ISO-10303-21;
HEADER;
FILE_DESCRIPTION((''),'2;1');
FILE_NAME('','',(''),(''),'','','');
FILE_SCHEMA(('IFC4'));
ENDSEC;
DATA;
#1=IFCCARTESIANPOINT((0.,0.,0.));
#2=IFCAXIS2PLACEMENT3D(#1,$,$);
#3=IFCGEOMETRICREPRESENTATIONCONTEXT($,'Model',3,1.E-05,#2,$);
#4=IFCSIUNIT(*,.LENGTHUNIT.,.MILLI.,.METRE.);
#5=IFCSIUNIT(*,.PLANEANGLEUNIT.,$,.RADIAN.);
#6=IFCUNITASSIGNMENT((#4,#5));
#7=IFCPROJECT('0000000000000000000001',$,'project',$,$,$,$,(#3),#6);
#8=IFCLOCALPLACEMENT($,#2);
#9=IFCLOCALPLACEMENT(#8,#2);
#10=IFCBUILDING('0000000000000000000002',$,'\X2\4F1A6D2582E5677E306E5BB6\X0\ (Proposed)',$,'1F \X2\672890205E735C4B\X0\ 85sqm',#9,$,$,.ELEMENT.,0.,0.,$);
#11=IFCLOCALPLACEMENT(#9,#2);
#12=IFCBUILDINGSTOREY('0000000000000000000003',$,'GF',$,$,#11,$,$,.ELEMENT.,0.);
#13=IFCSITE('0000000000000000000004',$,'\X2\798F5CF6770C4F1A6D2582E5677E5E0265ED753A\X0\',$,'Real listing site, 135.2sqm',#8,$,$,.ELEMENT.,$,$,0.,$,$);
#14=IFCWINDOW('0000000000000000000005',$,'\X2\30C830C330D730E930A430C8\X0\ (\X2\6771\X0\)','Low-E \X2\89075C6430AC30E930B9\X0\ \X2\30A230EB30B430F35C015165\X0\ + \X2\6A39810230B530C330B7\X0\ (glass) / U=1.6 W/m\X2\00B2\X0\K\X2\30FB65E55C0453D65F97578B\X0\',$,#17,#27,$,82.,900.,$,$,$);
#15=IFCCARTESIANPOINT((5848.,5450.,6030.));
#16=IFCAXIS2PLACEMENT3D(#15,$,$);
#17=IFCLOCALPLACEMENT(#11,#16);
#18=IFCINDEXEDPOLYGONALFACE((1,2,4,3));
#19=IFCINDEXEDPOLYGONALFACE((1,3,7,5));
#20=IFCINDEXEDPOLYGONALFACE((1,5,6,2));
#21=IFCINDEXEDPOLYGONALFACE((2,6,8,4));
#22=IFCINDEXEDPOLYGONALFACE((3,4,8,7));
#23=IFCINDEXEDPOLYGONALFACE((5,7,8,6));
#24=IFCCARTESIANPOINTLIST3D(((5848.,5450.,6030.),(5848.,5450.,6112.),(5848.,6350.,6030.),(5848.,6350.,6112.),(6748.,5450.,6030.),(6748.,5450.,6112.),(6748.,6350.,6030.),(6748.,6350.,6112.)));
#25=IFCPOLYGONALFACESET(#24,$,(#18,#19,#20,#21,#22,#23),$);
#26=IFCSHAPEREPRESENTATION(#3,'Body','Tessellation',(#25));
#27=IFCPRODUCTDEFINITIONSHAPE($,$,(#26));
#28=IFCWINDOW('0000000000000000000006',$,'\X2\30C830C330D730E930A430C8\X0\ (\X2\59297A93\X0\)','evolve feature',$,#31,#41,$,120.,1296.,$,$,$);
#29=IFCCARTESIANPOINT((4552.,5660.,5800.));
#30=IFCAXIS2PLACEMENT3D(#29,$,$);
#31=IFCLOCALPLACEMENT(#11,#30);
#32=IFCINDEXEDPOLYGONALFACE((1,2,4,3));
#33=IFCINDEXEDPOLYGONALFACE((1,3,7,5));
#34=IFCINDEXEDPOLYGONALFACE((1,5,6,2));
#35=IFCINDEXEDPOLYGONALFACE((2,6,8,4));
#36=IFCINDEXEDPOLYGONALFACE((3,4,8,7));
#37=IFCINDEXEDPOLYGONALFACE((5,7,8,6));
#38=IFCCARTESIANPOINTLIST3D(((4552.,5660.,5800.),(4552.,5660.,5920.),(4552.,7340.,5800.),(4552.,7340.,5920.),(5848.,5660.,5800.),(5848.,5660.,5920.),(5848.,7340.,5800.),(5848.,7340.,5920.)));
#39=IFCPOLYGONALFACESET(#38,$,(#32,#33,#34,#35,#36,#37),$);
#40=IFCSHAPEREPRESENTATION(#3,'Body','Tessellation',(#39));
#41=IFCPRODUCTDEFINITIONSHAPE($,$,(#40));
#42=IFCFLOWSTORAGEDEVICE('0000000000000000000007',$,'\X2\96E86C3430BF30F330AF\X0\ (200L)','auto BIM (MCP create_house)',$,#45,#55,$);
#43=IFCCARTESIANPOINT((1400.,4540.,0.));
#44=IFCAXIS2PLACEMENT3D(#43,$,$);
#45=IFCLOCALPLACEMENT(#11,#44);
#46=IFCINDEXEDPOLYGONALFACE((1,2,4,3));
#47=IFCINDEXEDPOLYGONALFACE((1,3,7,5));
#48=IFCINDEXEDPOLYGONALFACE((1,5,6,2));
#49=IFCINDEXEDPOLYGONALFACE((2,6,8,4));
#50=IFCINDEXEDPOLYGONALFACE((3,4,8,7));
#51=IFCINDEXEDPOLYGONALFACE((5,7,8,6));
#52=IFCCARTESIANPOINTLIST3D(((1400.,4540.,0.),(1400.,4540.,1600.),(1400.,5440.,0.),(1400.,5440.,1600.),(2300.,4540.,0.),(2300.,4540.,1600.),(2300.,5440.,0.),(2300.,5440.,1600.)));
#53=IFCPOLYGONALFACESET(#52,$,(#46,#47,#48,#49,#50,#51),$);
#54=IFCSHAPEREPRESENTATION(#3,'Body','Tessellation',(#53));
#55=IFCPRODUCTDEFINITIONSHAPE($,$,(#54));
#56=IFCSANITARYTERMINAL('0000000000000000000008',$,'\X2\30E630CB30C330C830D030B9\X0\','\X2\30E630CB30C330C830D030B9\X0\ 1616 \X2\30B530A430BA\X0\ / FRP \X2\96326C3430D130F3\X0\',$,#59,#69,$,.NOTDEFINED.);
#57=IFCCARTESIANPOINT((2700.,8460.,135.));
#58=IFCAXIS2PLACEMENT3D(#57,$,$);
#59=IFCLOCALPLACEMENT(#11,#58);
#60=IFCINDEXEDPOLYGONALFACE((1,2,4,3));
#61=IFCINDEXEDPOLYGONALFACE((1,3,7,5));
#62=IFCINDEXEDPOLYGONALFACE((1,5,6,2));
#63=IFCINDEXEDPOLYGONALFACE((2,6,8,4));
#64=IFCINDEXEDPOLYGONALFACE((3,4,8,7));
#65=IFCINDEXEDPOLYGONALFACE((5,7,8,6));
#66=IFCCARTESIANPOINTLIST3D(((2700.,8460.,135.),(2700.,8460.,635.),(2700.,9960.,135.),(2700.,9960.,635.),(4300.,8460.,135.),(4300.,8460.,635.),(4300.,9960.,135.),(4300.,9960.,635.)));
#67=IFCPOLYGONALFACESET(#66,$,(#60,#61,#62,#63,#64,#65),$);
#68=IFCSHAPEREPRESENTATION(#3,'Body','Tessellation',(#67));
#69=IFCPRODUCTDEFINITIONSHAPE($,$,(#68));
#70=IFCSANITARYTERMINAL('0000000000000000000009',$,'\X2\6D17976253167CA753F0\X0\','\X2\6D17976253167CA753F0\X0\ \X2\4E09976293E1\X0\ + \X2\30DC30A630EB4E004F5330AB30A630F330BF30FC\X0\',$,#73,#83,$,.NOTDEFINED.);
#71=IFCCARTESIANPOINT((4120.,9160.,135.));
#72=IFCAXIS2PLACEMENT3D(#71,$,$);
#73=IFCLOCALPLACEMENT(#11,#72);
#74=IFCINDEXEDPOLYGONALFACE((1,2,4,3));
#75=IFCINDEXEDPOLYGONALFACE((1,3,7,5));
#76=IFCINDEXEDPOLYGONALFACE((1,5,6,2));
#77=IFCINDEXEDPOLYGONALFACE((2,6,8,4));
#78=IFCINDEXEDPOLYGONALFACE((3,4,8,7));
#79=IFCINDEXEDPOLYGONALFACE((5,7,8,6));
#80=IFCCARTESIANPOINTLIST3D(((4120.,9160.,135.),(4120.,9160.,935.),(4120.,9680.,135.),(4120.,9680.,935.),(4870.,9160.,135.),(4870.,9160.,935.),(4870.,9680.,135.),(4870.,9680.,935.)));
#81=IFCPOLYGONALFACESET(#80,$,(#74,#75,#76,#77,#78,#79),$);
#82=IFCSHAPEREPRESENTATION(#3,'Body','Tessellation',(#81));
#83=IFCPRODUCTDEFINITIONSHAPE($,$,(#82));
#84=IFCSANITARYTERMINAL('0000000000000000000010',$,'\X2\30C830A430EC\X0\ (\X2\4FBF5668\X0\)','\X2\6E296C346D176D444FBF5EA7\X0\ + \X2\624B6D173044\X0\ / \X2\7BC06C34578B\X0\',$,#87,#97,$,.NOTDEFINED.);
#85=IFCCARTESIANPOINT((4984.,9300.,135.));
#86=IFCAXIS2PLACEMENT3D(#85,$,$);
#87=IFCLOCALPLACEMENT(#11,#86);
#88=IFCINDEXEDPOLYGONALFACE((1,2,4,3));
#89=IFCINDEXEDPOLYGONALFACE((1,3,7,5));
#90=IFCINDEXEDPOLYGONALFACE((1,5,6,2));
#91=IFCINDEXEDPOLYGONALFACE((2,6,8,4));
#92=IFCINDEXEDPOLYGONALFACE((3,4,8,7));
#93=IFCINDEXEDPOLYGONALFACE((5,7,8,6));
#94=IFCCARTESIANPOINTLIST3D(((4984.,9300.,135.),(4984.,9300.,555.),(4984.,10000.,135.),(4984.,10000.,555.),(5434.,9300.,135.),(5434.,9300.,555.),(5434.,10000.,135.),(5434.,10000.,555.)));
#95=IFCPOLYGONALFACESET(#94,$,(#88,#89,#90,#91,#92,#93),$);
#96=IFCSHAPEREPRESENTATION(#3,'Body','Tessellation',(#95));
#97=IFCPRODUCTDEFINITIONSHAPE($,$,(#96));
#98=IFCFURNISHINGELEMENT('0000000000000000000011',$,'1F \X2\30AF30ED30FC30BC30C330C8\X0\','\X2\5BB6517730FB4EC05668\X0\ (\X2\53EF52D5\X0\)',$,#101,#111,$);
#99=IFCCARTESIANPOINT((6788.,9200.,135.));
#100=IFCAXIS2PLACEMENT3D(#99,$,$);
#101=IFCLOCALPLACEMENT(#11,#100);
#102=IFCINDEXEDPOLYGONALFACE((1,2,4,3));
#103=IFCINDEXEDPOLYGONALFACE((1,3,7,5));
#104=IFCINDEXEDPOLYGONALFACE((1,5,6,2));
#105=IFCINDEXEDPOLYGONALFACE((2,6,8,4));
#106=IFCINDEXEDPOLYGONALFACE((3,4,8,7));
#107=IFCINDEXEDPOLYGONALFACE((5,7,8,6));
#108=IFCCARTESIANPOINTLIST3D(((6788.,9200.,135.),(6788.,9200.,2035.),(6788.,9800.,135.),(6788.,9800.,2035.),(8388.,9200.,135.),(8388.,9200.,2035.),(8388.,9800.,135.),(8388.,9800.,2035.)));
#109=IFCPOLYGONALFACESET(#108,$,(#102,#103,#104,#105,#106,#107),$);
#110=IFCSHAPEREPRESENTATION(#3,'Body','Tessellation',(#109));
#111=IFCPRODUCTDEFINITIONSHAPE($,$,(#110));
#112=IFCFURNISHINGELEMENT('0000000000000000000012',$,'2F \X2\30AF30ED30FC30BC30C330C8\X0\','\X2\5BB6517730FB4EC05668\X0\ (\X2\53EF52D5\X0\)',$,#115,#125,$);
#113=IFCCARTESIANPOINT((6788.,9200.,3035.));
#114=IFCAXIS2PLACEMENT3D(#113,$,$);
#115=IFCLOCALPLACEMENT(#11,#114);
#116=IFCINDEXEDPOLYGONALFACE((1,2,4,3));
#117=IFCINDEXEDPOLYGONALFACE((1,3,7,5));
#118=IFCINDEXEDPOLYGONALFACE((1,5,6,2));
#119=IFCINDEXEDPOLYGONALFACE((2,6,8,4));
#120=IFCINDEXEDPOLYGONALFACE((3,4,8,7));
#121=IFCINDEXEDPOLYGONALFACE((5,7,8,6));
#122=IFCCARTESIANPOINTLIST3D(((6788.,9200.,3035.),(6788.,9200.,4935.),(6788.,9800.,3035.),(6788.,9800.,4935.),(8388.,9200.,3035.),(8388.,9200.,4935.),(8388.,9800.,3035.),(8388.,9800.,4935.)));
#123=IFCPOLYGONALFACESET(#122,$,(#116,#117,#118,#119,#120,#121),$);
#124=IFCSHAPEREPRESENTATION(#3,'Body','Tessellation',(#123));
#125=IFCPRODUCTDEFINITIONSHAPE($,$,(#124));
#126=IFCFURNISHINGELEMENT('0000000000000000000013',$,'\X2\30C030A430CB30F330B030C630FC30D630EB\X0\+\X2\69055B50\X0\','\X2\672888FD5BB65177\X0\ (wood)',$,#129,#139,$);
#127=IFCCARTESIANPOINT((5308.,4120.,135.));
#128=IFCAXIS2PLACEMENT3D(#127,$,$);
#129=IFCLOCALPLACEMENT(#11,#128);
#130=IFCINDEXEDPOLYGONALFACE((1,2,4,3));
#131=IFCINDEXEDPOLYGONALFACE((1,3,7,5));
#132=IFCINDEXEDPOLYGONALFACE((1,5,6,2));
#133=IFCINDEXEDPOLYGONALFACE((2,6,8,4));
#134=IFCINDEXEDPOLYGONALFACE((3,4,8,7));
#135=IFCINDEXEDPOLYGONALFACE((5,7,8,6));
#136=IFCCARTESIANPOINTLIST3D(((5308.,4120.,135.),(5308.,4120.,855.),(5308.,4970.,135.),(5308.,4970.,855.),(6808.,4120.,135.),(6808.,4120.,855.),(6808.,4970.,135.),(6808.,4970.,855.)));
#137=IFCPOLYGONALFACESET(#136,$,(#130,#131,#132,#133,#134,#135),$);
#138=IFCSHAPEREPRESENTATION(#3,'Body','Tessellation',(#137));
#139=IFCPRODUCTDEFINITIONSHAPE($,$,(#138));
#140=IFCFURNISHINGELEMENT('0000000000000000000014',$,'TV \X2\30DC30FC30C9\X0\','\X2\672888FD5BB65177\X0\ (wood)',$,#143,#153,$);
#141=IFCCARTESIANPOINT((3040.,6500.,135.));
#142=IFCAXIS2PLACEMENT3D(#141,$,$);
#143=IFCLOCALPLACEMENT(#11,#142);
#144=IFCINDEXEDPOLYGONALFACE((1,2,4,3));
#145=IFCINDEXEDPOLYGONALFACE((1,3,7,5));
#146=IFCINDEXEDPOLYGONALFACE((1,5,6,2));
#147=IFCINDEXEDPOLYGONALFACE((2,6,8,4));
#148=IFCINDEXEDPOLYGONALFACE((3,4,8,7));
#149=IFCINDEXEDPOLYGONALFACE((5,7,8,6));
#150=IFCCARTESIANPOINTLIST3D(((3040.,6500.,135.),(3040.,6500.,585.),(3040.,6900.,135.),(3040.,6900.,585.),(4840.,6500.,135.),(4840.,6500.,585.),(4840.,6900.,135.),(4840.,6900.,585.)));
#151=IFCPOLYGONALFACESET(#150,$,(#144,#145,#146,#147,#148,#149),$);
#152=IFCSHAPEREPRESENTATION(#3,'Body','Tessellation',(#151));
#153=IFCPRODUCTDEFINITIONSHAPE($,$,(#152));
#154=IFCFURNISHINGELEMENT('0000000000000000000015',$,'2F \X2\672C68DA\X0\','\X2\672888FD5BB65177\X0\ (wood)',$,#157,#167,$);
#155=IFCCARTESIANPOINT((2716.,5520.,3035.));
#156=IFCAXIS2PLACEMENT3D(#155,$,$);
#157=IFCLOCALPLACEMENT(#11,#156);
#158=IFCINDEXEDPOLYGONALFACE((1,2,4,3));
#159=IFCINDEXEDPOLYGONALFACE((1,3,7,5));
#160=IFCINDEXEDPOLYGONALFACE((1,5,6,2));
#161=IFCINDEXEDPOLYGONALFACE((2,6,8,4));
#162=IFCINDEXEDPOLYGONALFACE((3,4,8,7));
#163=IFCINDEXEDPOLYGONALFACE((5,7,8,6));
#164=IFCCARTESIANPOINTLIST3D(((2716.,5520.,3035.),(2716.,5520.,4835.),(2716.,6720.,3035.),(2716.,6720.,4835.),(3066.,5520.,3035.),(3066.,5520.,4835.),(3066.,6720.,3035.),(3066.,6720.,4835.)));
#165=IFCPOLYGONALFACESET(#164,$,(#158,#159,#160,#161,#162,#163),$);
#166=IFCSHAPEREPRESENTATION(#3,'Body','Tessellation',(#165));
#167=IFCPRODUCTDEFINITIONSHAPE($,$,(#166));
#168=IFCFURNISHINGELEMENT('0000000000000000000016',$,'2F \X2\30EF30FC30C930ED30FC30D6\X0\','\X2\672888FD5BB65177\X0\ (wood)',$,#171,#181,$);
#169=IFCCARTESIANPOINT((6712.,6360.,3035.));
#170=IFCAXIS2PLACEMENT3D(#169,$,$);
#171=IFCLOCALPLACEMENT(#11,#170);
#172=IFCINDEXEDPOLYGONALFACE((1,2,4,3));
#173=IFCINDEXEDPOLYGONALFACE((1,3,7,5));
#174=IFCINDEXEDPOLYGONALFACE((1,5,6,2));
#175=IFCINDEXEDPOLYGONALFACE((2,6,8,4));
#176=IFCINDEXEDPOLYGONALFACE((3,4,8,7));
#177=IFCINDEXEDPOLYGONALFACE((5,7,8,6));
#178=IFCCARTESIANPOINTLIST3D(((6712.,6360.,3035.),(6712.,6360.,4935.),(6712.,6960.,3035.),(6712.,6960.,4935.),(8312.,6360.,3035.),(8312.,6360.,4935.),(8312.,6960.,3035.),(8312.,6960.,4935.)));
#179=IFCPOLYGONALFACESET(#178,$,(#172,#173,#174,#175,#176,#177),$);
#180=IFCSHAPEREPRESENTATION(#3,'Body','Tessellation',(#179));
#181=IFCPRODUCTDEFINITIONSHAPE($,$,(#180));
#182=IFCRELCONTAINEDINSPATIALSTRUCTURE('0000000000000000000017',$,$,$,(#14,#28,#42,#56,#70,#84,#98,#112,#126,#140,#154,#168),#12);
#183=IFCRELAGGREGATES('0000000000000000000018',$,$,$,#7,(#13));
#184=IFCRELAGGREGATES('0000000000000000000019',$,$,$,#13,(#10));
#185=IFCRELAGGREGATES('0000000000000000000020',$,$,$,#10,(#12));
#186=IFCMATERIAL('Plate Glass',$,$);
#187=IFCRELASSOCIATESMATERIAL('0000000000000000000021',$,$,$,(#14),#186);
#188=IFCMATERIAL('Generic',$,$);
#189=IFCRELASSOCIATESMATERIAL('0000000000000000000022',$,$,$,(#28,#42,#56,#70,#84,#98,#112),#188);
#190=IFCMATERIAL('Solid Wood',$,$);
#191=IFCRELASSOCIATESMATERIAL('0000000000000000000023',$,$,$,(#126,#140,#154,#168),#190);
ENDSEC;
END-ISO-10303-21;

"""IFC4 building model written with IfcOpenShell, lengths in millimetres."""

from ifc_helpers import new_model, si_unit, frame, frame_2d, origin, place, context, project, spatial, rectangle, extrude, material, element, save


model = new_model("IFC4")

# Units and contexts
model_context = context("Model", 3, precision=1e-05, world=origin())
ifc_project = project(units=[si_unit("LENGTHUNIT", "METRE", prefix="MILLI"), si_unit("PLANEANGLEUNIT", "RADIAN")], contexts=[model_context])

# Site, building, storey
site_placement = place(None, origin())
site = spatial("IfcSite", under=ifc_project, at=site_placement, Name="福島県会津若松市旭町", ObjectType="Real listing site, 135.2sqm", CompositionType="ELEMENT", RefElevation=0.0)
building_placement = place(site_placement, origin())
building = spatial("IfcBuilding", under=site, at=building_placement, Name="会津若松の家 (Proposed)", ObjectType="1F 木造平屋 85sqm", CompositionType="ELEMENT", ElevationOfRefHeight=0.0, ElevationOfTerrain=0.0)
storey_placement = place(building_placement, origin())
storey = spatial("IfcBuildingStorey", under=building, at=storey_placement, Name="GF", CompositionType="ELEMENT", Elevation=0.0)

# Shared definitions
ifc_material_1 = material(Name="Solid Wood")
ifc_material_2 = material(Name="Plate Glass")

# Windows
window_1_placement = place(storey_placement, frame((5848.0, 5450.0, 6030.0)))
element("IfcWindow", 1, at=window_1_placement, inside=storey, material=ifc_material_2, Name="トップライト (東)", Description="Low-E 複層ガラス アルゴン封入 + 樹脂サッシ (glass) / U=1.6 W/m²K・日射取得型", OverallHeight=82.0, OverallWidth=900.0, context=model_context, shape_type="SweptSolid", body=[
    extrude(rectangle(XDim=900.0, YDim=900.0, at=frame_2d((450.0, 450.0))), frame((5848.0, 5450.0, 6030.0)), (0.0, 0.0, 1.0), 82.0),
])
ifc_material_3 = material(Name="Generic")
window_2_placement = place(storey_placement, frame((4552.0, 5660.0, 5800.0)))
element("IfcWindow", 2, at=window_2_placement, inside=storey, material=ifc_material_3, Name="トップライト (天窓)", Description="evolve feature", OverallHeight=120.0, OverallWidth=1296.0, context=model_context, shape_type="SweptSolid", body=[
    extrude(rectangle(XDim=1296.0, YDim=1680.0, at=frame_2d((648.0, 840.0))), frame((4552.0, 5660.0, 5800.0)), (0.0, 0.0, 1.0), 120.0),
])

# Flow storage device
flow_storage_device_placement = place(storey_placement, frame((1400.0, 4540.0, 0.0)))
element("IfcFlowStorageDevice", 3, at=flow_storage_device_placement, inside=storey, material=ifc_material_3, Name="雨水タンク (200L)", Description="auto BIM (MCP create_house)", context=model_context, shape_type="SweptSolid", body=[
    extrude(rectangle(XDim=900.0, YDim=900.0, at=frame_2d((450.0, 450.0))), frame((1400.0, 4540.0, 0.0)), (0.0, 0.0, 1.0), 1600.0),
])

# Sanitary terminals
sanitary_terminal_1_placement = place(storey_placement, frame((2700.0, 8460.0, 135.0)))
element("IfcSanitaryTerminal", 4, at=sanitary_terminal_1_placement, inside=storey, material=ifc_material_3, Name="ユニットバス", Description="ユニットバス 1616 サイズ / FRP 防水パン", PredefinedType="NOTDEFINED", context=model_context, shape_type="SweptSolid", body=[
    extrude(rectangle(XDim=1600.0, YDim=1500.0, at=frame_2d((800.0, 750.0))), frame((2700.0, 8460.0, 135.0)), (0.0, 0.0, 1.0), 500.0),
])
sanitary_terminal_2_placement = place(storey_placement, frame((4120.0, 9160.0, 135.0)))
element("IfcSanitaryTerminal", 5, at=sanitary_terminal_2_placement, inside=storey, material=ifc_material_3, Name="洗面化粧台", Description="洗面化粧台 三面鏡 + ボウル一体カウンター", PredefinedType="NOTDEFINED", context=model_context, shape_type="SweptSolid", body=[
    extrude(rectangle(XDim=750.0, YDim=520.0, at=frame_2d((375.0, 260.0))), frame((4120.0, 9160.0, 135.0)), (0.0, 0.0, 1.0), 800.0),
])
sanitary_terminal_3_placement = place(storey_placement, frame((4984.0, 9300.0, 135.0)))
element("IfcSanitaryTerminal", 6, at=sanitary_terminal_3_placement, inside=storey, material=ifc_material_3, Name="トイレ (便器)", Description="温水洗浄便座 + 手洗い / 節水型", PredefinedType="NOTDEFINED", context=model_context, shape_type="SweptSolid", body=[
    extrude(rectangle(XDim=450.0, YDim=700.0, at=frame_2d((225.0, 350.0))), frame((4984.0, 9300.0, 135.0)), (0.0, 0.0, 1.0), 420.0),
])

# Furnishing elements
furnishing_1_placement = place(storey_placement, frame((6788.0, 9200.0, 135.0)))
element("IfcFurnishingElement", 7, at=furnishing_1_placement, inside=storey, material=ifc_material_3, Name="1F クローゼット", Description="家具・什器 (可動)", context=model_context, shape_type="SweptSolid", body=[
    extrude(rectangle(XDim=1600.0, YDim=600.0, at=frame_2d((800.0, 300.0))), frame((6788.0, 9200.0, 135.0)), (0.0, 0.0, 1.0), 1900.0),
])
furnishing_2_placement = place(storey_placement, frame((6788.0, 9200.0, 3035.0)))
element("IfcFurnishingElement", 8, at=furnishing_2_placement, inside=storey, material=ifc_material_3, Name="2F クローゼット", Description="家具・什器 (可動)", context=model_context, shape_type="SweptSolid", body=[
    extrude(rectangle(XDim=1600.0, YDim=600.0, at=frame_2d((800.0, 300.0))), frame((6788.0, 9200.0, 3035.0)), (0.0, 0.0, 1.0), 1900.0),
])
furnishing_3_placement = place(storey_placement, frame((5308.0, 4120.0, 135.0)))
element("IfcFurnishingElement", 9, at=furnishing_3_placement, inside=storey, material=ifc_material_1, Name="ダイニングテーブル+椅子", Description="木製家具 (wood)", context=model_context, shape_type="SweptSolid", body=[
    extrude(rectangle(XDim=1500.0, YDim=850.0, at=frame_2d((750.0, 425.0))), frame((5308.0, 4120.0, 135.0)), (0.0, 0.0, 1.0), 720.0),
])
furnishing_4_placement = place(storey_placement, frame((3040.0, 6500.0, 135.0)))
element("IfcFurnishingElement", 10, at=furnishing_4_placement, inside=storey, material=ifc_material_1, Name="TV ボード", Description="木製家具 (wood)", context=model_context, shape_type="SweptSolid", body=[
    extrude(rectangle(XDim=1800.0, YDim=400.0, at=frame_2d((900.0, 200.0))), frame((3040.0, 6500.0, 135.0)), (0.0, 0.0, 1.0), 450.0),
])
furnishing_5_placement = place(storey_placement, frame((2716.0, 5520.0, 3035.0)))
element("IfcFurnishingElement", 11, at=furnishing_5_placement, inside=storey, material=ifc_material_1, Name="2F 本棚", Description="木製家具 (wood)", context=model_context, shape_type="SweptSolid", body=[
    extrude(rectangle(XDim=350.0, YDim=1200.0, at=frame_2d((175.0, 600.0))), frame((2716.0, 5520.0, 3035.0)), (0.0, 0.0, 1.0), 1800.0),
])
furnishing_6_placement = place(storey_placement, frame((6712.0, 6360.0, 3035.0)))
element("IfcFurnishingElement", 12, at=furnishing_6_placement, inside=storey, material=ifc_material_1, Name="2F ワードローブ", Description="木製家具 (wood)", context=model_context, shape_type="SweptSolid", body=[
    extrude(rectangle(XDim=1600.0, YDim=600.0, at=frame_2d((800.0, 300.0))), frame((6712.0, 6360.0, 3035.0)), (0.0, 0.0, 1.0), 1900.0),
])

save(model, "model.ifc")
